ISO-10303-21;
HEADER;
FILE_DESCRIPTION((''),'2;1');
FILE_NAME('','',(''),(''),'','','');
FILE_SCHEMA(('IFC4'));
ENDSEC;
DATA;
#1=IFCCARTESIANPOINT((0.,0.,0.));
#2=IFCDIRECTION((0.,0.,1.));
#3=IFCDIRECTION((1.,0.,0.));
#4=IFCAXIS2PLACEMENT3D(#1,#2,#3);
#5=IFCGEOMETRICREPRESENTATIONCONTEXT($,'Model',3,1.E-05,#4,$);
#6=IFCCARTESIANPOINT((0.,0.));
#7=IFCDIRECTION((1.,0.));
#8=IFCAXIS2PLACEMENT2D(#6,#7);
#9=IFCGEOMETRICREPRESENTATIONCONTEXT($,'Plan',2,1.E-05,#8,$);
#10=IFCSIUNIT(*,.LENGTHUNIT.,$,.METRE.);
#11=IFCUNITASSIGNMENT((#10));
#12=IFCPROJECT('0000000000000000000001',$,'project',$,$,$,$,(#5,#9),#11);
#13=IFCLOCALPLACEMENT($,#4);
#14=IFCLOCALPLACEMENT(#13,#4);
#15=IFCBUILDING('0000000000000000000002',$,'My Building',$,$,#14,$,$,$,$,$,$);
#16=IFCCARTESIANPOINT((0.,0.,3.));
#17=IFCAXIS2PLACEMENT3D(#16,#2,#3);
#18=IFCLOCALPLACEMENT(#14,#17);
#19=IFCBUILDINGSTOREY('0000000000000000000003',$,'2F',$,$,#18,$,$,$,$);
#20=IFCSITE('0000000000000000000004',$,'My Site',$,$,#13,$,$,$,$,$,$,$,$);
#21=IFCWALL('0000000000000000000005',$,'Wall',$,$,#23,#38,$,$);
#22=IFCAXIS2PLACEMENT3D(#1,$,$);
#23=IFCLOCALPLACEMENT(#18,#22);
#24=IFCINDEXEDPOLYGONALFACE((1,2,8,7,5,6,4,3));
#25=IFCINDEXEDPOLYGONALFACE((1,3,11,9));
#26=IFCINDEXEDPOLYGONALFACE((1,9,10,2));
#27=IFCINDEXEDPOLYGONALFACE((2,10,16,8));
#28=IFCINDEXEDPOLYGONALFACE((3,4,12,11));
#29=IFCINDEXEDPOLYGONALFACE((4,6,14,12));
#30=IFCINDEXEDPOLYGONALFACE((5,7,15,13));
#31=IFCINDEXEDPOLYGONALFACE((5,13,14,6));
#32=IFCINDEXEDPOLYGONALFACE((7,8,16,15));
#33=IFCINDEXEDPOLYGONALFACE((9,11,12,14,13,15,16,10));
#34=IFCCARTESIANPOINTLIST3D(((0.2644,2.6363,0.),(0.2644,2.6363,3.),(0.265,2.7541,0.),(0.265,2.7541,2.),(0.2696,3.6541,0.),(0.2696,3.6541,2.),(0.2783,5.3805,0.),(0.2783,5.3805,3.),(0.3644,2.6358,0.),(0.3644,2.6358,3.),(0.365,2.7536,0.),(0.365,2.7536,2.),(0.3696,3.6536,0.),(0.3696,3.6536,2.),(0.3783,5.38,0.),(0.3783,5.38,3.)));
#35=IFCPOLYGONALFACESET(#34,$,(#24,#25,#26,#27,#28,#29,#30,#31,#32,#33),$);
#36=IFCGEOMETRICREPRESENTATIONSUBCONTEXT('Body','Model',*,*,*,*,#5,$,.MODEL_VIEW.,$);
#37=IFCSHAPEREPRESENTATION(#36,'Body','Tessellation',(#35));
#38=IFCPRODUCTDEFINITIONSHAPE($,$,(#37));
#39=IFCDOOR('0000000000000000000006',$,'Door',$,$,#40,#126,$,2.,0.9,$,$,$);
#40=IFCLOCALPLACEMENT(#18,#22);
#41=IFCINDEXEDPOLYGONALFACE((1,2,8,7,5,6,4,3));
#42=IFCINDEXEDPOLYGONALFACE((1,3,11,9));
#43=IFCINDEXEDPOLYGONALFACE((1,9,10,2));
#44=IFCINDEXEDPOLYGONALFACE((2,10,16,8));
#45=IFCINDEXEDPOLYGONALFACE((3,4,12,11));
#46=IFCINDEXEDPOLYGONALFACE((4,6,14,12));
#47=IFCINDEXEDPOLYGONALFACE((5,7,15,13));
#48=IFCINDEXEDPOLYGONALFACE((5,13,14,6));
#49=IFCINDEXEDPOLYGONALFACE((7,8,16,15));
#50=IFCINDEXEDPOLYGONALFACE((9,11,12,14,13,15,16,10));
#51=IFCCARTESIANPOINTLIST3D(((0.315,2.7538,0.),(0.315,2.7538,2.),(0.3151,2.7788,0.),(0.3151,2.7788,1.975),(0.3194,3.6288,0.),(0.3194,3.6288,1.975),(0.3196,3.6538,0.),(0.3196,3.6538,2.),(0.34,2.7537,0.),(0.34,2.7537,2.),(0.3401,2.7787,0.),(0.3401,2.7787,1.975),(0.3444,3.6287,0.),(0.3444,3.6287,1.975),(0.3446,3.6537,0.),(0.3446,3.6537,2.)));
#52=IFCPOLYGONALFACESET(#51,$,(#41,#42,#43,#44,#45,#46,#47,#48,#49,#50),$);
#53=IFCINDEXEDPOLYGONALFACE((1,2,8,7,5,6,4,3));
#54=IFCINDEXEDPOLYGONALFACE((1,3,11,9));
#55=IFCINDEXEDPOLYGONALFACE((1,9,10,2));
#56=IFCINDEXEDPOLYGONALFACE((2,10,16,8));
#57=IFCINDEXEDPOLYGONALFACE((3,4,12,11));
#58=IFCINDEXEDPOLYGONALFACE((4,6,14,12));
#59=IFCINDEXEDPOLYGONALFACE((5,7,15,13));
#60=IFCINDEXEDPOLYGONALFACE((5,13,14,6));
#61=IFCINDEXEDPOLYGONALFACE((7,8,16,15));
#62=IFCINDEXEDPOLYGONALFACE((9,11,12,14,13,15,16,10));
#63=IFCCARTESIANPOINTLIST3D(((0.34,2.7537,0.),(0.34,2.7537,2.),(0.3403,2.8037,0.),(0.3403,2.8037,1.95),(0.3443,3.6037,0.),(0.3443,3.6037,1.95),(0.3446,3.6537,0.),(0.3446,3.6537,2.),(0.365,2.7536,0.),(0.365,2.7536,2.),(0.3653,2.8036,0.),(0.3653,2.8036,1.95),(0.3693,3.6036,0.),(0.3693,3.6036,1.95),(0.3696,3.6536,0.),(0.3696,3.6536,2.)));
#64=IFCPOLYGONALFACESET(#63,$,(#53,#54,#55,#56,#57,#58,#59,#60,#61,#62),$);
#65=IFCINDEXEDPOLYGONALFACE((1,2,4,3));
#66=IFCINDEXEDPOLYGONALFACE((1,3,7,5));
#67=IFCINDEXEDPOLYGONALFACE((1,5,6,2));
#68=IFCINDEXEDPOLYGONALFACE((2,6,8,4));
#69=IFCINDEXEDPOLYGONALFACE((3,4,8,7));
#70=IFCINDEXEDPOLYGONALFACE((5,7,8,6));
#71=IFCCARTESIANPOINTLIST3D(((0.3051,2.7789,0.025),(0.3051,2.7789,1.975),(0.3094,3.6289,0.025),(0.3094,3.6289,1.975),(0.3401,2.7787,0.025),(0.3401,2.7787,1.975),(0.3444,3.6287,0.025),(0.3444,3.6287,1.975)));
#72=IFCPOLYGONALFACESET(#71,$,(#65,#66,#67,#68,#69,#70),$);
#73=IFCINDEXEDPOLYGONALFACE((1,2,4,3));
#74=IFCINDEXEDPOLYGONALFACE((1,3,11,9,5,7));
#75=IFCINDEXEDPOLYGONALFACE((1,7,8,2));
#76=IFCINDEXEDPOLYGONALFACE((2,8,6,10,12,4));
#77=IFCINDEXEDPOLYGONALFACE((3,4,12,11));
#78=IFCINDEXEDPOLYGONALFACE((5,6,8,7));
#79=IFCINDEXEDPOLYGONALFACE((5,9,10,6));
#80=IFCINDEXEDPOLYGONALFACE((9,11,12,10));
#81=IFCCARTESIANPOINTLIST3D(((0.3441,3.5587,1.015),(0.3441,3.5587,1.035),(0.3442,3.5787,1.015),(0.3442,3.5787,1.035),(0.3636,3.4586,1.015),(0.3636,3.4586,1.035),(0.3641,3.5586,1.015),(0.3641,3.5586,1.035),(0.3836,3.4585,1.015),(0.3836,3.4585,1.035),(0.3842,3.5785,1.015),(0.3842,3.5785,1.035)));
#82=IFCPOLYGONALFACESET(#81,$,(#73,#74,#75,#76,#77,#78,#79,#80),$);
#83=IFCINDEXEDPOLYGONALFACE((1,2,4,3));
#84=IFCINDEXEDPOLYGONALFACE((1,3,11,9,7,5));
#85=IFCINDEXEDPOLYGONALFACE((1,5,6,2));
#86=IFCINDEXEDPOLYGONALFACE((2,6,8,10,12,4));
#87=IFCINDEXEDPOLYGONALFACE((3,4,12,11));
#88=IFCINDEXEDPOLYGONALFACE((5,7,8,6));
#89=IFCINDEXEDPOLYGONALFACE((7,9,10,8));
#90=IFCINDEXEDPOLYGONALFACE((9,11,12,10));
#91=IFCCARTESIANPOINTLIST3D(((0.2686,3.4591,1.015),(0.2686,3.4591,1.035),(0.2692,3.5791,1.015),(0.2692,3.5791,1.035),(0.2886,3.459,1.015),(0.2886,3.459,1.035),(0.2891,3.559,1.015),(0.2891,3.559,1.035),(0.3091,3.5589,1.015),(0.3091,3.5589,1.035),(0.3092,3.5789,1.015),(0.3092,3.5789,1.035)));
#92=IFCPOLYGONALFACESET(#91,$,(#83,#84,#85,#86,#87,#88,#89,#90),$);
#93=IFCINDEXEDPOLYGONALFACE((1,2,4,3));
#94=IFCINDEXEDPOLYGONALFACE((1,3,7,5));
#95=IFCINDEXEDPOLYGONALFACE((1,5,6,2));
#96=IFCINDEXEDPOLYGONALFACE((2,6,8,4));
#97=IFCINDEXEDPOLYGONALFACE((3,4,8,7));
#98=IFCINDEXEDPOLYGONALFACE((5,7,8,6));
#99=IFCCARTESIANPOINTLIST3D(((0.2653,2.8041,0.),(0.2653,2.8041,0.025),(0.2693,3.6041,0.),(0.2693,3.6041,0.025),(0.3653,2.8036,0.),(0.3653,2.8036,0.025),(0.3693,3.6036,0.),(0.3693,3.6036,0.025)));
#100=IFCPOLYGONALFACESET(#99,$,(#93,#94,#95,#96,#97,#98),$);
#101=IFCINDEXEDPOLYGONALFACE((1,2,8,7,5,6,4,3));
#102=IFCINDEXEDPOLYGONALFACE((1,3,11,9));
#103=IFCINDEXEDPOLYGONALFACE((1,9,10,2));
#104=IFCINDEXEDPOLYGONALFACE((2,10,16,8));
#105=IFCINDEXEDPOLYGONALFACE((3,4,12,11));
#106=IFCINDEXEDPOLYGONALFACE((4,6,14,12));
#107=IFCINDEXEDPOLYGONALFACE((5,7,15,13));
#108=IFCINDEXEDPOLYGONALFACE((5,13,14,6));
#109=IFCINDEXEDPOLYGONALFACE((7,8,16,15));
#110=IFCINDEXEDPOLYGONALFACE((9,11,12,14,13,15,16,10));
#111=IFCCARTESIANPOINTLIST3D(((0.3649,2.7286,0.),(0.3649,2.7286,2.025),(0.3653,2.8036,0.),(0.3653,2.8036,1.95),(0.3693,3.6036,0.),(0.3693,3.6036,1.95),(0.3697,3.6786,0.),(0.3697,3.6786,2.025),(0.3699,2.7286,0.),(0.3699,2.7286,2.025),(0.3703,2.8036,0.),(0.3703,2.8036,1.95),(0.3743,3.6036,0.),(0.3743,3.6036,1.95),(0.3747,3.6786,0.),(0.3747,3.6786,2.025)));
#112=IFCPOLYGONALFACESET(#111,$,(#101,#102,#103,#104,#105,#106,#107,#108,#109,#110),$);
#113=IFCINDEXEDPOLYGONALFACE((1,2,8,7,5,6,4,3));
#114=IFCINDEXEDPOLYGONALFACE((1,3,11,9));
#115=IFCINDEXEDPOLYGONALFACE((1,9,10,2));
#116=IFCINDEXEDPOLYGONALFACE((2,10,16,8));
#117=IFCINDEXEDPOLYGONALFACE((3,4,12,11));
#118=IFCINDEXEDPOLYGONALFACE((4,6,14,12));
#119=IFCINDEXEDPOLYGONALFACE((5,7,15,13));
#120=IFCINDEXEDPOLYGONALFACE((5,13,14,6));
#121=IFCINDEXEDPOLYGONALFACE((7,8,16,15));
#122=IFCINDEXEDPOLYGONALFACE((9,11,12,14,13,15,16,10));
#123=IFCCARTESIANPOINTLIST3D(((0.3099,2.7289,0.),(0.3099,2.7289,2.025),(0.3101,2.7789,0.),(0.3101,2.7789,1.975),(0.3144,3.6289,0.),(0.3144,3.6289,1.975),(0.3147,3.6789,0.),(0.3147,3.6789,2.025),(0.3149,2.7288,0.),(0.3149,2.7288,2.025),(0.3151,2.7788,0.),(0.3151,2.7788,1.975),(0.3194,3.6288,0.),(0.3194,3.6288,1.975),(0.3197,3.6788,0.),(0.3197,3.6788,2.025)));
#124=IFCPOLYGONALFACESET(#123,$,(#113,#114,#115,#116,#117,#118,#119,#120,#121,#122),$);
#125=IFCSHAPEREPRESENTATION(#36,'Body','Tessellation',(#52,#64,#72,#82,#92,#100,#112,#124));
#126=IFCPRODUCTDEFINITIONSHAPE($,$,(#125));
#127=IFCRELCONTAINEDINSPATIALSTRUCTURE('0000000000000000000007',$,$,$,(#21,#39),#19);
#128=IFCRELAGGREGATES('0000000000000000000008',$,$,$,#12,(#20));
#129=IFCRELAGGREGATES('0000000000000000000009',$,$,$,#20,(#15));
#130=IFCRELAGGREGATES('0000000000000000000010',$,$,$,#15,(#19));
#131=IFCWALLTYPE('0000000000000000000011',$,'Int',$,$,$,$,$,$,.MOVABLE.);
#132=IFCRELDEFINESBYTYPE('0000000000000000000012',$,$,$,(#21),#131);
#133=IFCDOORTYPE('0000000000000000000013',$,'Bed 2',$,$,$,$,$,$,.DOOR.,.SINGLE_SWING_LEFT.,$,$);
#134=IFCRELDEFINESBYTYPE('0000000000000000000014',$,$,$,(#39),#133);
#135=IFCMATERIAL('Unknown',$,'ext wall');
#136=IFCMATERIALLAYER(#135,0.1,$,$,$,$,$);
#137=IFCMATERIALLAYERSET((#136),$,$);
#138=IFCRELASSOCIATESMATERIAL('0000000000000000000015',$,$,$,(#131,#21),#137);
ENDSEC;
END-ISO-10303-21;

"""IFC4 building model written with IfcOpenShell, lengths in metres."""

from ifc_helpers import new_model, entity, si_unit, frame, origin_with_axes, origin_2d_with_axis, place, context, subcontext, project, spatial, line, indexed_curve, outline, extrude, shape, source, transform, mapped, material, layer, layer_set, layer_usage, type_object, type_shapes, element, fill, save


model = new_model("IFC4")

# Units and contexts
model_context = context("Model", 3, precision=1e-05, world=origin_with_axes())
plan_context = context("Plan", 2, precision=1e-05, world=origin_2d_with_axis())
body_context_1 = subcontext(model_context, "Body", "Model", "MODEL_VIEW")
body_context_2 = subcontext(plan_context, "Body", "Plan", "PLAN_VIEW")
ifc_project = project(units=[si_unit("LENGTHUNIT", "METRE")], contexts=[model_context, plan_context])

# Site, building, storey
site_placement = place(None, origin_with_axes())
site = spatial("IfcSite", under=ifc_project, at=site_placement, Name="My Site")
building_placement = place(site_placement, origin_with_axes())
building = spatial("IfcBuilding", under=site, at=building_placement, Name="My Building")
storey_placement = place(building_placement, frame((0.0, 0.0, 3.0), z_axis=(0.0, 0.0, 1.0), x_axis=(1.0, 0.0, 0.0)))
storey = spatial("IfcBuildingStorey", under=building, at=storey_placement, Name="2F")

# Shared definitions
ifc_material = material(Name="Unknown", Category="ext wall")

# Wall, opening, door
ifc_layer_1 = layer(ifc_material, 0.1)
ifc_layer_set_1 = layer_set([ifc_layer_1])
ifc_layer_usage_1 = layer_usage(ifc_layer_set_1, "AXIS2", "POSITIVE", 0.0)
wall_type_1 = type_object("IfcWallType", Name="Int", PredefinedType="MOVABLE", material=ifc_layer_set_1)
wall_1_placement = place(storey_placement, frame((0.3644, 2.6358, 0.0), z_axis=(0.0, 0.0, 1.0), x_axis=(0.005081, 0.999987, 0.0)))
wall_1 = element("IfcWall", 1, at=wall_1_placement, inside=storey, type_object=wall_type_1, material=ifc_layer_usage_1, Name="Wall", context=body_context_1, shape_type="SweptSolid", body=[
    extrude(outline(indexed_curve([(0.0, 0.0), (0.0, 0.1), (2.7442, 0.1), (2.7442, 0.0)], segments=[line(1, 2, 3, 4, 1)])), origin_with_axes(), (0.0, 0.0, 1.0), 3.0),
])
shared_shape_1 = source(origin_with_axes(), body_context_1, "Body", "SweptSolid", [
    extrude(outline(indexed_curve([(0.0, 0.0), (0.9, 0.0), (0.9, 2.0), (0.0, 2.0)], segments=[line(1, 2, 3, 4, 1)])), frame((0.0, -0.6, 0.0), z_axis=(0.0, -1.0, 0.0), x_axis=(1.0, 0.0, 0.0)), (0.0, 0.0, -1.0), 1.2),
])
opening_1_placement = place(wall_1_placement, frame((0.1178, 0.0, 0.0), z_axis=(0.0, 0.0, 1.0), x_axis=(1.0, 0.000001, 0.0)))
opening_1 = element("IfcOpeningElement", 2, at=opening_1_placement, cuts=wall_1, PredefinedType="OPENING", context=body_context_1, shape_type="MappedRepresentation", body=[
    mapped(shared_shape_1, transform((0.0, 0.0, 0.0), x_axis=(1.0, 0.0, 0.0), y_axis=(0.0, 1.0, 0.0), z_axis=(0.0, 0.0, 1.0), scale=1.0)),
])
door_type_1 = type_object("IfcDoorType", Name="Bed 2", OperationType="SINGLE_SWING_LEFT", PredefinedType="DOOR")
shared_shape_2 = source(origin_with_axes(), body_context_1, "Body", "SweptSolid", [
    extrude(outline(indexed_curve([(0.0, 0.0), (0.0, 2.0), (0.9, 2.0), (0.9, 0.0), (0.875, 0.0), (0.875, 1.975), (0.025, 1.975), (0.025, 0.0)], segments=[line(1, 2, 3, 4, 5, 6, 7, 8, 1)])), frame((0.0, 0.025, 0.0), z_axis=(0.0, -1.0, 0.0), x_axis=(1.0, 0.0, 0.0)), (0.0, 0.0, -1.0), 0.025),
    extrude(outline(indexed_curve([(0.0, 0.0), (0.0, 2.0), (0.9, 2.0), (0.9, 0.0), (0.85, 0.0), (0.85, 1.95), (0.05, 1.95), (0.05, 0.0)], segments=[line(1, 2, 3, 4, 5, 6, 7, 8, 1)])), frame((0.0, 0.0, 0.0), z_axis=(0.0, -1.0, 0.0), x_axis=(1.0, 0.0, 0.0)), (0.0, 0.0, -1.0), 0.025),
    extrude(outline(indexed_curve([(0.0, 0.0), (0.85, 0.0), (0.85, 0.035), (0.0, 0.035)], segments=[line(1, 2, 3, 4, 1)])), frame((0.025, 0.025, 0.025), z_axis=(0.0, 0.0, 1.0), x_axis=(1.0, 0.0, 0.0)), (0.0, 0.0, 1.0), 1.95),
    extrude(outline(indexed_curve([(0.0, 0.0), (0.0, -0.04), (-0.12, -0.04), (-0.12, -0.02), (-0.02, -0.02), (-0.02, 0.0)], segments=[line(1, 2, 3, 4, 5, 6, 1)])), frame((0.825, 0.025, 1.015), z_axis=(0.0, 0.0, 1.0), x_axis=(1.0, 0.0, 0.0)), (0.0, 0.0, 1.0), 0.02),
    extrude(outline(indexed_curve([(0.0, 0.0), (0.0, 0.04), (-0.12, 0.04), (-0.12, 0.02), (-0.02, 0.02), (-0.02, 0.0)], segments=[line(1, 2, 3, 4, 5, 6, 1)])), frame((0.825, 0.06, 1.015), z_axis=(0.0, 0.0, 1.0), x_axis=(1.0, 0.0, 0.0)), (0.0, 0.0, 1.0), 0.02),
    extrude(outline(indexed_curve([(0.0, 0.0), (0.8, 0.0), (0.8, 0.1), (0.0, 0.1)], segments=[line(1, 2, 3, 4, 1)])), frame((0.05, 0.0, 0.0), z_axis=(0.0, 0.0, 1.0), x_axis=(1.0, 0.0, 0.0)), (0.0, 0.0, 1.0), 0.025),
    extrude(outline(indexed_curve([(0.0, 0.0), (0.0, 2.025), (0.95, 2.025), (0.95, 0.0), (0.875, 0.0), (0.875, 1.95), (0.075, 1.95), (0.075, 0.0)], segments=[line(1, 2, 3, 4, 5, 6, 7, 8, 1)])), frame((-0.025, -0.005, 0.0), z_axis=(0.0, -1.0, 0.0), x_axis=(1.0, 0.0, 0.0)), (0.0, 0.0, -1.0), 0.005),
    extrude(outline(indexed_curve([(0.0, 0.0), (0.0, 2.025), (0.95, 2.025), (0.95, 0.0), (0.9, 0.0), (0.9, 1.975), (0.05, 1.975), (0.05, 0.0)], segments=[line(1, 2, 3, 4, 5, 6, 7, 8, 1)])), frame((-0.025, 0.05, 0.0), z_axis=(0.0, -1.0, 0.0), x_axis=(1.0, 0.0, 0.0)), (0.0, 0.0, -1.0), 0.005),
])
shared_shape_3 = source(origin_with_axes(), body_context_2, "Body", "Curve2D", [
    entity("IfcIndexedPolyCurve", entity("IfcCartesianPointList2D", [[0.0, 0.0], [0.0, 0.05], [0.025, 0.05], [0.025, 0.025], [0.05, 0.025], [0.05, 0.0]]), [entity("IfcLineIndex", [1, 2, 3, 4, 5, 6, 1])]),
    entity("IfcIndexedPolyCurve", entity("IfcCartesianPointList2D", [[0.9, 0.0], [0.9, 0.05], [0.875, 0.05], [0.875, 0.025], [0.85, 0.025], [0.85, 0.0]]), [entity("IfcLineIndex", [1, 2, 3, 4, 5, 6, 1])]),
    entity("IfcTrimmedCurve", entity("IfcEllipse", entity("IfcAxis2Placement2D", entity("IfcCartesianPoint", [0.06, 0.05]), entity("IfcDirection", [1.0, 0.0])), 0.815, 0.85), [entity("IfcCartesianPoint", [0.875, 0.05])], [entity("IfcCartesianPoint", [0.06, 0.9])], True, "CARTESIAN"),
    entity("IfcIndexedPolyCurve", entity("IfcCartesianPointList2D", [[0.025, 0.05], [0.06, 0.05], [0.06, 0.9], [0.025, 0.9]]), [entity("IfcLineIndex", [1, 2, 3, 4, 1])]),
])
type_shapes(door_type_1, [shared_shape_2, shared_shape_3])
door_1_placement = place(opening_1_placement, frame((0.0, 0.0, 0.0), z_axis=(0.0, 0.0, 1.0), x_axis=(1.0, 0.0, 0.0)))
door_1 = element("IfcDoor", 3, at=door_1_placement, inside=storey, type_object=door_type_1, Name="Door", OverallHeight=2.0, OverallWidth=0.9, shapes=[
    shape(body_context_1, "Body", "MappedRepresentation", [mapped(shared_shape_2, transform((0.0, 0.0, 0.0), x_axis=(1.0, 0.0, 0.0), y_axis=(0.0, 1.0, 0.0), z_axis=(0.0, 0.0, 1.0), scale=1.0))]),
    shape(body_context_2, "Body", "MappedRepresentation", [mapped(shared_shape_3, transform((0.0, 0.0, 0.0), x_axis=(1.0, 0.0, 0.0), y_axis=(0.0, 1.0, 0.0), z_axis=(0.0, 0.0, 1.0), scale=1.0))]),
])
fill(opening_1, door_1)

save(model, "model.ifc")
